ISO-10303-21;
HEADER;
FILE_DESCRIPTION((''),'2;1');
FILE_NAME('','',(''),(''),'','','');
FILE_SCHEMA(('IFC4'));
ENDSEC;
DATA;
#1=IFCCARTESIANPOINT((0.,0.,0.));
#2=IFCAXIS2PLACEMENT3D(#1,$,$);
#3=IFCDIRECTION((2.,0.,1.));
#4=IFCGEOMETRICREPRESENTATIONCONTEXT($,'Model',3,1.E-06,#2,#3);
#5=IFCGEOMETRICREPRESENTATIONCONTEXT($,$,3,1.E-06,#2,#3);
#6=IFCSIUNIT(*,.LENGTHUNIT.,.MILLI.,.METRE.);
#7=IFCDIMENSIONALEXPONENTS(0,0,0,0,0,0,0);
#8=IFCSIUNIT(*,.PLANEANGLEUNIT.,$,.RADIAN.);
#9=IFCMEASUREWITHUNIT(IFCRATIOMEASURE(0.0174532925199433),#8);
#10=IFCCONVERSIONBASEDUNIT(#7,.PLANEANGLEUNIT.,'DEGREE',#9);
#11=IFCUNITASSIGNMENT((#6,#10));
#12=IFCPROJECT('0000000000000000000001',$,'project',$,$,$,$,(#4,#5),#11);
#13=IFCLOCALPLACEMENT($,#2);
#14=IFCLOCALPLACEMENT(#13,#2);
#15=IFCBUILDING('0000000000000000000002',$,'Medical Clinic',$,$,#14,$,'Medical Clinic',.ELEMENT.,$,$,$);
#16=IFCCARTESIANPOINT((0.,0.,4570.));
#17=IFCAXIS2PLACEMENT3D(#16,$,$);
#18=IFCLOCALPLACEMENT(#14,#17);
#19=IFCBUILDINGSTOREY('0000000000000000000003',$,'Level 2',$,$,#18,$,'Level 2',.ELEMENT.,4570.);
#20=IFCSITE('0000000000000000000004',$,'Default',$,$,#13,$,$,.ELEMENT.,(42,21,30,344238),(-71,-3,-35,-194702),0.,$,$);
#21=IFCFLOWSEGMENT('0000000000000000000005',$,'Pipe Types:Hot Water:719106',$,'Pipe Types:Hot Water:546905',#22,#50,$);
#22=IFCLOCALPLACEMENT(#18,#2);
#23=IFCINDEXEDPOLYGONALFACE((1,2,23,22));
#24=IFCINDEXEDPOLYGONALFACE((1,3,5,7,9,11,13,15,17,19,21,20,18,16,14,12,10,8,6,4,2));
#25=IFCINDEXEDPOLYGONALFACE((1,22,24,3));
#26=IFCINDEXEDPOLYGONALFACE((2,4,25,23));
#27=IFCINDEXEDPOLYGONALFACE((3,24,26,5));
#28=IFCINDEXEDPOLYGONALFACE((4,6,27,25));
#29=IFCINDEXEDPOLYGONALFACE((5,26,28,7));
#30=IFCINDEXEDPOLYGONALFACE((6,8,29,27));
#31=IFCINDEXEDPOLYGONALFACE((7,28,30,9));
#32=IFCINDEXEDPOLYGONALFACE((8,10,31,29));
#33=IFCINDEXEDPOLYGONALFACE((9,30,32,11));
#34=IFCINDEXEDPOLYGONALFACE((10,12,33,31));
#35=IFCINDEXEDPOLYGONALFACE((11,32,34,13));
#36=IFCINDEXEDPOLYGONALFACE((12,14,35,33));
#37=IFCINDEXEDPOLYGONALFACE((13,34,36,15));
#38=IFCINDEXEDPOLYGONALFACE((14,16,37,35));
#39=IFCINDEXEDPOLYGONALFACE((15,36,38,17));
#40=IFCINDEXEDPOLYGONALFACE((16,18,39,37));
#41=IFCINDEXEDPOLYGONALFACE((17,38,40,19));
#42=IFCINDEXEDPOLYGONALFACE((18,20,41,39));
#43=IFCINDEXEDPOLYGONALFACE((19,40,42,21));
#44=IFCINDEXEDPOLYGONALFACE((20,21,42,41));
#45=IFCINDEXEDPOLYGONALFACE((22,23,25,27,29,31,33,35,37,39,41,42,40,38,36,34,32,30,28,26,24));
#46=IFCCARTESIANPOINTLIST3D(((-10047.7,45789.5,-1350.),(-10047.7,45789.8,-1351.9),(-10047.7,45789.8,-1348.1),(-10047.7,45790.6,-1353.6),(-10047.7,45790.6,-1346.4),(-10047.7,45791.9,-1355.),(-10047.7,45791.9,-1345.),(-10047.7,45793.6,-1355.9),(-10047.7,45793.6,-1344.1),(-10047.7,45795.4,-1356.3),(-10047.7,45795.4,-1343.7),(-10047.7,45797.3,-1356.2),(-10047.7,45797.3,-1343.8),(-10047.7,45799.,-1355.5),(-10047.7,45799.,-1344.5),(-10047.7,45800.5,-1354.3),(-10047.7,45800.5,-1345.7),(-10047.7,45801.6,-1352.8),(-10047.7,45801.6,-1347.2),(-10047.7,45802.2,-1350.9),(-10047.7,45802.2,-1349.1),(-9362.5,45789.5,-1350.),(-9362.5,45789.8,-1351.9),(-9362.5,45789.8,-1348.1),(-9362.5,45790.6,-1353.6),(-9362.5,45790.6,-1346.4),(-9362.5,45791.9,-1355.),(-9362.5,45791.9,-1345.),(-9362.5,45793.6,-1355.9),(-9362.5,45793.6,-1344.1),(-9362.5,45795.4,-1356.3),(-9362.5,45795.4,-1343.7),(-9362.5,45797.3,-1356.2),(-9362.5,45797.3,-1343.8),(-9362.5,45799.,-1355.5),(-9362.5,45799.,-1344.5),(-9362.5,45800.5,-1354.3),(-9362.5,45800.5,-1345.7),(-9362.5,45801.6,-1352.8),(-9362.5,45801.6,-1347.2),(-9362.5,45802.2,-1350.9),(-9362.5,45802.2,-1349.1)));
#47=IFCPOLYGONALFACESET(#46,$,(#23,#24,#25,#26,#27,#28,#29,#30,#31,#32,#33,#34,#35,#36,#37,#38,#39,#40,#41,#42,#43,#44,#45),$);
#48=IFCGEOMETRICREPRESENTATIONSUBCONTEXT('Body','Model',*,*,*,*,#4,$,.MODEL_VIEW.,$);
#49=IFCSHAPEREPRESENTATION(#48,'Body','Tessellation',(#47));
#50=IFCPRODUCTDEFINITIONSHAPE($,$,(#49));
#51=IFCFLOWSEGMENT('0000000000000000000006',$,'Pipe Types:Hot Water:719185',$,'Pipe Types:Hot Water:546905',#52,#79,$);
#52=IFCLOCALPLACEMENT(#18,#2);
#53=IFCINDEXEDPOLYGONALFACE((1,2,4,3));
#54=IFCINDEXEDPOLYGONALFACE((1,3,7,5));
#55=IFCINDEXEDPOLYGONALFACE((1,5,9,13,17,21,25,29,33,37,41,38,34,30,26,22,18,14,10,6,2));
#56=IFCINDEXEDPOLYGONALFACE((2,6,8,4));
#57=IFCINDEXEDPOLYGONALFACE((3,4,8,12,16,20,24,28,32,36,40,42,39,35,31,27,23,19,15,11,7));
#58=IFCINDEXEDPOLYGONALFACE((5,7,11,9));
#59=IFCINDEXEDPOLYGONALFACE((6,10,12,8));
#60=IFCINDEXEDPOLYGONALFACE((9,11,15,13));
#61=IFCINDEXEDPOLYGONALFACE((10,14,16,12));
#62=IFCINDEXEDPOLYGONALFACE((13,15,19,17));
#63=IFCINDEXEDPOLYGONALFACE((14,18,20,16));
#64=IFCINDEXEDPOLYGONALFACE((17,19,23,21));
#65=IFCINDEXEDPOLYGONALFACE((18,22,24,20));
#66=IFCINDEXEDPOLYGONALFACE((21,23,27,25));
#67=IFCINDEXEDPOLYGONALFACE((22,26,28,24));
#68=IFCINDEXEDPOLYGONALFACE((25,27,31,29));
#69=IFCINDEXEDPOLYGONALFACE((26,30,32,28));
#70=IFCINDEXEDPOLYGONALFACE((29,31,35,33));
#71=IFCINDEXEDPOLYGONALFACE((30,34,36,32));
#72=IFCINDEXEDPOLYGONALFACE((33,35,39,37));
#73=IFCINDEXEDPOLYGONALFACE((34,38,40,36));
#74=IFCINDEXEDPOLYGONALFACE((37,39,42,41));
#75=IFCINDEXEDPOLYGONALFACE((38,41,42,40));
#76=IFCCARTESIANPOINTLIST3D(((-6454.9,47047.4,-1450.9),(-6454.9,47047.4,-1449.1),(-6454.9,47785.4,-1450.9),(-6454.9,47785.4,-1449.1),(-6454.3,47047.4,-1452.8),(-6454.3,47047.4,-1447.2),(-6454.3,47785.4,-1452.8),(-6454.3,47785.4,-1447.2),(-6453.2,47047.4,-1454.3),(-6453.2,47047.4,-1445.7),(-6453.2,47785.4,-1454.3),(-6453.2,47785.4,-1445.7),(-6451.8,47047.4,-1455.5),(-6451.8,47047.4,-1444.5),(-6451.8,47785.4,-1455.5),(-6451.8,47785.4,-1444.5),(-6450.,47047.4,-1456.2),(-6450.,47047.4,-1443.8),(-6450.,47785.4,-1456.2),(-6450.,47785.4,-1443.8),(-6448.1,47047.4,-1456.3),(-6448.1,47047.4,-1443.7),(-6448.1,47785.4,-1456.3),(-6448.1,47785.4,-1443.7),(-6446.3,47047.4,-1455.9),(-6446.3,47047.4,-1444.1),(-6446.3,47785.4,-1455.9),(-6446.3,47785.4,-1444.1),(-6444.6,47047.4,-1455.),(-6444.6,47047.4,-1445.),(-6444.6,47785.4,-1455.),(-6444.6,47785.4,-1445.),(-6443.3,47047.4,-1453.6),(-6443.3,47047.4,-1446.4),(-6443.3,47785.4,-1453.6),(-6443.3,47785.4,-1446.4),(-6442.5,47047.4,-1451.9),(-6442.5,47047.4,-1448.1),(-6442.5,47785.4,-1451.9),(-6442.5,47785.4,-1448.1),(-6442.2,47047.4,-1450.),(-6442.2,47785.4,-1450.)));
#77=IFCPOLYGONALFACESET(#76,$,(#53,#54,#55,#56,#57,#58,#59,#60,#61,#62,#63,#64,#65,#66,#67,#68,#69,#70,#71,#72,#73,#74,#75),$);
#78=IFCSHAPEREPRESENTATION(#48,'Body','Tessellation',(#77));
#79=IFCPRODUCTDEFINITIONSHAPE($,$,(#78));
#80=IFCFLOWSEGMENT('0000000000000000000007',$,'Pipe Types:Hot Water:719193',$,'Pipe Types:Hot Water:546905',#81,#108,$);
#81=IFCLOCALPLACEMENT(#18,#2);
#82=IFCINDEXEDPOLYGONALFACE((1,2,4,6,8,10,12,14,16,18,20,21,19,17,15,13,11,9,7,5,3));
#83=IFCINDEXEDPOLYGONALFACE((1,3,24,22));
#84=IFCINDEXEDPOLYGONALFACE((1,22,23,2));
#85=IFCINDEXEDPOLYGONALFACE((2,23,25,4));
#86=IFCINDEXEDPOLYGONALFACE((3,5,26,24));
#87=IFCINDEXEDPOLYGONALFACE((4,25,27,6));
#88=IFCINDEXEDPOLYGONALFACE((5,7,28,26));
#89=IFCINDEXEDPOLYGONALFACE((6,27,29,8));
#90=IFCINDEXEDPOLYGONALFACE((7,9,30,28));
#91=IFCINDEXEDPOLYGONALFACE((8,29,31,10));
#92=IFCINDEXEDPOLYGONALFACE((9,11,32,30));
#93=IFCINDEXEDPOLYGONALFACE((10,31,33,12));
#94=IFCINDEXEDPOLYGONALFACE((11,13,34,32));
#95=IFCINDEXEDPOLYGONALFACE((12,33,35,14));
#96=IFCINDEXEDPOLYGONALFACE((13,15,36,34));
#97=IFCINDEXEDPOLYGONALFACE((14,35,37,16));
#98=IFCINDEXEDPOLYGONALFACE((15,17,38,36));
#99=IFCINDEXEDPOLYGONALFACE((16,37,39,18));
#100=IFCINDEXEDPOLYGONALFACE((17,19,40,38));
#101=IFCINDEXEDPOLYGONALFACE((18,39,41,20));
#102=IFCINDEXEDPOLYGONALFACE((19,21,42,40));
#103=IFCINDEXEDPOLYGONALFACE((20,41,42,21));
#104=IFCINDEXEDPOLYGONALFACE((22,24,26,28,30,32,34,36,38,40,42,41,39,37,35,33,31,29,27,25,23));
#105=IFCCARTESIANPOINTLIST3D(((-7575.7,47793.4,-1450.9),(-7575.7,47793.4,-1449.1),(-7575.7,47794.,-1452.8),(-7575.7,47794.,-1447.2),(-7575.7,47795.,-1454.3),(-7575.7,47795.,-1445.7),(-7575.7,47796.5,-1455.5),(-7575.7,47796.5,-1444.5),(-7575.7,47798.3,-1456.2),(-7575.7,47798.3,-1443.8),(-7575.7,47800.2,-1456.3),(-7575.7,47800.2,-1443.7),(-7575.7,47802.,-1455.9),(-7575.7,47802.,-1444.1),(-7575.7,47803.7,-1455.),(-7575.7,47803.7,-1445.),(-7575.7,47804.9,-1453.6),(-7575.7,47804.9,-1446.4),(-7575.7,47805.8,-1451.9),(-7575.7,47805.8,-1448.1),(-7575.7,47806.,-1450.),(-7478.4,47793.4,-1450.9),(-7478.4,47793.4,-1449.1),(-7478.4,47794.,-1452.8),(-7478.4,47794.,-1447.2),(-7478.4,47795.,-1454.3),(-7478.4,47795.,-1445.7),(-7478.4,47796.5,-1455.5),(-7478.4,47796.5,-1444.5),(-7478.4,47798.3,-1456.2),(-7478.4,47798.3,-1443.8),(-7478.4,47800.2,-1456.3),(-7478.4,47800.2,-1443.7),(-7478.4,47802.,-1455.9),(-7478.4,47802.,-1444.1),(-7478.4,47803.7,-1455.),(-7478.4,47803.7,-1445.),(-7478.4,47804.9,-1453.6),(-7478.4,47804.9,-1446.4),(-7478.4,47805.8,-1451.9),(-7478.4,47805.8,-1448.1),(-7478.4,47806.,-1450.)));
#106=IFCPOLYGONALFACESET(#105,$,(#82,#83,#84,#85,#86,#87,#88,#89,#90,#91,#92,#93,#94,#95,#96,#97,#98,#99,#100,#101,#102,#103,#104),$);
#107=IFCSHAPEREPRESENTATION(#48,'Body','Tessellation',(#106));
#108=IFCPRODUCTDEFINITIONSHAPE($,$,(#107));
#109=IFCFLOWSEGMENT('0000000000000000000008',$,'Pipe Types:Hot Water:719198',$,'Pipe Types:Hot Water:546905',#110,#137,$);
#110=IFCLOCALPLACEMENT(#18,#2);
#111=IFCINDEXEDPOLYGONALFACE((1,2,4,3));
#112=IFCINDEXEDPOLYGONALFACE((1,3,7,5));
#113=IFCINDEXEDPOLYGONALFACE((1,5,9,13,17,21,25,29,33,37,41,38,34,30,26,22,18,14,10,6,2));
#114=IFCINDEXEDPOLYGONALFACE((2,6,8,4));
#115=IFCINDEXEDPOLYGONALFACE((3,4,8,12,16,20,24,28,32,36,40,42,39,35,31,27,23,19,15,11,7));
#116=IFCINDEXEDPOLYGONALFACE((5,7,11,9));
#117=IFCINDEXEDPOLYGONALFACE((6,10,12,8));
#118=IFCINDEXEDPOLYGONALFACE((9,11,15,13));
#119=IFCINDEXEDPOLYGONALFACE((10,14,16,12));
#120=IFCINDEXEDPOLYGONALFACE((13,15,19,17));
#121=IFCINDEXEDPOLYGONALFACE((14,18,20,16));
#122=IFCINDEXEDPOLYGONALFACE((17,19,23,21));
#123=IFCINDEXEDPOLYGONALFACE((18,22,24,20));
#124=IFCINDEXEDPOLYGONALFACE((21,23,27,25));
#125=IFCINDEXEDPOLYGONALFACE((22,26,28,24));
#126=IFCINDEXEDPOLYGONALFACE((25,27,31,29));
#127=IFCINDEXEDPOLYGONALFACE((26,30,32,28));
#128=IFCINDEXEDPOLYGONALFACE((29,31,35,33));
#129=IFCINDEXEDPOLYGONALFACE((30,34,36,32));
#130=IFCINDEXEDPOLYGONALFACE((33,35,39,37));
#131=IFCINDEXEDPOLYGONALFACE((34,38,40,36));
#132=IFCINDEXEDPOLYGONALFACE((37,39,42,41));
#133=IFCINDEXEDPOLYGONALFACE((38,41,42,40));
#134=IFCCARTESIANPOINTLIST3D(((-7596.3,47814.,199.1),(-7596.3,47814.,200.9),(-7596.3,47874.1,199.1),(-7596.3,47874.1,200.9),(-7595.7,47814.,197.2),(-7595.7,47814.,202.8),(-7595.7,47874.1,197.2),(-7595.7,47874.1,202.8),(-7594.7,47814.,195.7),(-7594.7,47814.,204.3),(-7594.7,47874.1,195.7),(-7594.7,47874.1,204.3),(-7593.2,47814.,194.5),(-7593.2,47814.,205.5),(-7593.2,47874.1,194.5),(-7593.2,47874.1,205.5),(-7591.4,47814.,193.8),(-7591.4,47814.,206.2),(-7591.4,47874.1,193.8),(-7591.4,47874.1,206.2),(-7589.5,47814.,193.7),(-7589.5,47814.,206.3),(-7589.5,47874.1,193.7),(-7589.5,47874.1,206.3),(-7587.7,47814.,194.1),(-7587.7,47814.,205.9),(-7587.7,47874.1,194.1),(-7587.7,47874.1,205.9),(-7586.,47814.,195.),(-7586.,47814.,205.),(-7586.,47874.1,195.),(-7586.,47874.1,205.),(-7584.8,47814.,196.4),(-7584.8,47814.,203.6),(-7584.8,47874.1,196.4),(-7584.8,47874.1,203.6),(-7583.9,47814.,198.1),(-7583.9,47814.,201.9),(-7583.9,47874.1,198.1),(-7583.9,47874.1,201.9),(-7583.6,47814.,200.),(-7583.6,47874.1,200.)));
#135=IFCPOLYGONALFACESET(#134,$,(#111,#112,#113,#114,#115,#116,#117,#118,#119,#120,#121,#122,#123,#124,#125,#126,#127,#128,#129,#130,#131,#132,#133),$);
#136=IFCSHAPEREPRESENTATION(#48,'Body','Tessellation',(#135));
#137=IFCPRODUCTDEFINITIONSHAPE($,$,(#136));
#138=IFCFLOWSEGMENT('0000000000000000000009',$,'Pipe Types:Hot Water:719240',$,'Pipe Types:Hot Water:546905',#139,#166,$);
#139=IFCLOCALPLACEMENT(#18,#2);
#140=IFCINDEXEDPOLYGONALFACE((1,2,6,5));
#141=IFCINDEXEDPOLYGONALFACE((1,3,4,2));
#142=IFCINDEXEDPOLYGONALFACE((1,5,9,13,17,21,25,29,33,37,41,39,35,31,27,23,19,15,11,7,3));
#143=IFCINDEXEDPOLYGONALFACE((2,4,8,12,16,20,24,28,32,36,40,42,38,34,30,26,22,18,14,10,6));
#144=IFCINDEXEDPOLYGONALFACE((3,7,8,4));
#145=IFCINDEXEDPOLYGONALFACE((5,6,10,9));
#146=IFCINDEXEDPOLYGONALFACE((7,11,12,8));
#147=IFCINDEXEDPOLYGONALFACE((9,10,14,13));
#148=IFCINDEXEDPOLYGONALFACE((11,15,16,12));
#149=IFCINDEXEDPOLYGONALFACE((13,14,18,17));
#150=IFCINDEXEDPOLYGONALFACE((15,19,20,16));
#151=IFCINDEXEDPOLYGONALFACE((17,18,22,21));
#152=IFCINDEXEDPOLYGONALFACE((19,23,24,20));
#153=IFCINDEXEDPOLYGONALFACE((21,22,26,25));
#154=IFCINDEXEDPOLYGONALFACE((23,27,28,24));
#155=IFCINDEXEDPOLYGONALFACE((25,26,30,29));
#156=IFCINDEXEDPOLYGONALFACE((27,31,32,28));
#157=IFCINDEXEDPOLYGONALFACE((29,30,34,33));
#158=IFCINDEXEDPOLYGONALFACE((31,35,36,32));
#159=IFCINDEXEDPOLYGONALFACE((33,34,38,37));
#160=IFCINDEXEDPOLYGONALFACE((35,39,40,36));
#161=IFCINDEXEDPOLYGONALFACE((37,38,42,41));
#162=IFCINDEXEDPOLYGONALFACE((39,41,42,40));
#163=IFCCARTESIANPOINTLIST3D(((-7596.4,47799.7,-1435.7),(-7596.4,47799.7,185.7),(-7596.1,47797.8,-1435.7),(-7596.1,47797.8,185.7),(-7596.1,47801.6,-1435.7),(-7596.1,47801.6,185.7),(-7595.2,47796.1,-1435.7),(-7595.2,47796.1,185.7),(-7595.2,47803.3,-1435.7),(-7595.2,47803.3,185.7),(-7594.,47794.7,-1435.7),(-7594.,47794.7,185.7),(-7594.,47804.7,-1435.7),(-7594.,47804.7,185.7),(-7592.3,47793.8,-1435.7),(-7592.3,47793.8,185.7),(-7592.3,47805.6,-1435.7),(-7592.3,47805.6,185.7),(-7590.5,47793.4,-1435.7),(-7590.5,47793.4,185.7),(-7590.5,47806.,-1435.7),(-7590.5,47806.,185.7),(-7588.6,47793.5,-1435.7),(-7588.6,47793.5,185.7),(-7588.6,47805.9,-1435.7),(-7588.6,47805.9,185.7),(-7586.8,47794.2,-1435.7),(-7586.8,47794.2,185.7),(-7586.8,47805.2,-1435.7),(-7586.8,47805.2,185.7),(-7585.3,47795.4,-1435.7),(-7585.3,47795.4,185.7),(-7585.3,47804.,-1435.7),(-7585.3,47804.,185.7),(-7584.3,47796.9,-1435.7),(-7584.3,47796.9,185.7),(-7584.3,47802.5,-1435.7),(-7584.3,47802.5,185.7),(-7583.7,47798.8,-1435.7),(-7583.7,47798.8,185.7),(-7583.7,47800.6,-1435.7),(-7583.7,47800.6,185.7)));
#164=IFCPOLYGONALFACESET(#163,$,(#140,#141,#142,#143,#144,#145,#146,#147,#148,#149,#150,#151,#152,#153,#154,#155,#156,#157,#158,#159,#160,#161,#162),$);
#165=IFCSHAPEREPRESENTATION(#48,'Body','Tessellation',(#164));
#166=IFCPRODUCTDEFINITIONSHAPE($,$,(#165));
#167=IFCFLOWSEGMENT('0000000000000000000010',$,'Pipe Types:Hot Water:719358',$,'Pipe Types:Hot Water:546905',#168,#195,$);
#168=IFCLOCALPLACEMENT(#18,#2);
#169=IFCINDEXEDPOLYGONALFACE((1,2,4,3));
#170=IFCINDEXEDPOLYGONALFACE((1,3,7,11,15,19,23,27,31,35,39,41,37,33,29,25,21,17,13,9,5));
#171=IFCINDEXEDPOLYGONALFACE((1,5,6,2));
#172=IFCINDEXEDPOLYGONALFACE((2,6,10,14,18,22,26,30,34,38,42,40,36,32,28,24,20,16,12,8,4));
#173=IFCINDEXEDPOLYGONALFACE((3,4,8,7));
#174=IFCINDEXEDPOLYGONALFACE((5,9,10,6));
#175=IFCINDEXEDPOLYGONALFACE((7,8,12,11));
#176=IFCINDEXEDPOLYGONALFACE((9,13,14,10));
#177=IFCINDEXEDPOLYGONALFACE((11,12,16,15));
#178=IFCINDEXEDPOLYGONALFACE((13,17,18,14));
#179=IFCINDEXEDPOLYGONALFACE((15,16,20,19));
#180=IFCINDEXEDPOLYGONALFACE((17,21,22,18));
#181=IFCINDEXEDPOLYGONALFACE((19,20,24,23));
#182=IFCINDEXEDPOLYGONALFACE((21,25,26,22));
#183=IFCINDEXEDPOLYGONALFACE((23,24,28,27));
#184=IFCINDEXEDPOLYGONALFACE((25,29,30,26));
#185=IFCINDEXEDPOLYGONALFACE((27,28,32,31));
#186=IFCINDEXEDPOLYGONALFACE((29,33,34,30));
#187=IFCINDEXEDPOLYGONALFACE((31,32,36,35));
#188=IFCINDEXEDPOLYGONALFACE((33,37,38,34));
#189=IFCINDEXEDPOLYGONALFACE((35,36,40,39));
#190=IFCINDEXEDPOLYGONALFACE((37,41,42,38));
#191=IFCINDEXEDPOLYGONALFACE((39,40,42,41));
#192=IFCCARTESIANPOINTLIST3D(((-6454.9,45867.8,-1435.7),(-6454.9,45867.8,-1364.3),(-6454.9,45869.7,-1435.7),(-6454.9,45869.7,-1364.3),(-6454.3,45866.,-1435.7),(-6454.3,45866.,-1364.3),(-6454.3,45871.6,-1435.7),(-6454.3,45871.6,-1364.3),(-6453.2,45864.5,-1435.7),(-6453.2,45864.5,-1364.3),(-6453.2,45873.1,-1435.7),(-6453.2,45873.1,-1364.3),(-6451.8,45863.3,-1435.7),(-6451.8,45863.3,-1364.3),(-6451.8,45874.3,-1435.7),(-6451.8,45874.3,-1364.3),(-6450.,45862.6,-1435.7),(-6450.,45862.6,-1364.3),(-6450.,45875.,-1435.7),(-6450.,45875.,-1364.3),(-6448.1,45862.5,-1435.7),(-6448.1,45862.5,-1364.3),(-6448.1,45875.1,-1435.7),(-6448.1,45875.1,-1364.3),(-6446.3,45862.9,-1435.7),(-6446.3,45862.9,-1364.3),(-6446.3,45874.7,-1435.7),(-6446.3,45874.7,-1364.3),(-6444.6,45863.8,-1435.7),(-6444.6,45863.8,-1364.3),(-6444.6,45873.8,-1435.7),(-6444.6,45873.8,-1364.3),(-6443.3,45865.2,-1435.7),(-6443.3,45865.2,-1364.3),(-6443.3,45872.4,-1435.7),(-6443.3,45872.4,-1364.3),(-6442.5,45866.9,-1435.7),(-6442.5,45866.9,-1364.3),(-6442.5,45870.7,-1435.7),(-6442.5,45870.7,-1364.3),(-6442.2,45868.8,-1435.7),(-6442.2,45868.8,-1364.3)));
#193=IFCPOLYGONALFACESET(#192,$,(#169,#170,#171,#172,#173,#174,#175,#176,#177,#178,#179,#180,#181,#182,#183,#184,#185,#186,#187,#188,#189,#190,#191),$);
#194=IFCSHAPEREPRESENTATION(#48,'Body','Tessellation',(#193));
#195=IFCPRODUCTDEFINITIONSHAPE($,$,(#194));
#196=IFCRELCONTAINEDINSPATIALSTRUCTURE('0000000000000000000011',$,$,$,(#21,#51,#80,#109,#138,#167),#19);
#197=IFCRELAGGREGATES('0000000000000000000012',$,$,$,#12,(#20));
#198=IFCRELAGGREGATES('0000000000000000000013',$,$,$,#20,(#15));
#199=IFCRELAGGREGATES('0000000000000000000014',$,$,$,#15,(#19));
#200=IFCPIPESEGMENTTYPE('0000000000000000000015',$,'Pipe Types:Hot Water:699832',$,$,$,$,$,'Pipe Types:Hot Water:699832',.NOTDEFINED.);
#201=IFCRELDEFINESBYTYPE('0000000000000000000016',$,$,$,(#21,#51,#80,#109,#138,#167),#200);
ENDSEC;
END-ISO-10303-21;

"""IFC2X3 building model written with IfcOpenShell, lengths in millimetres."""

from ifc_helpers import new_model, entity, si_unit, converted_unit, direction, frame, frame_2d, origin, origin_2d_with_axis, place, context, subcontext, project, spatial, circle, extrude, type_object, element, save


model = new_model("IFC2X3")

# Units and contexts
model_context = context("Model", 3, precision=1e-06, world=origin(), true_north=direction((2.0, 0.0, 1.0)))
context_of_model = context(None, 3, precision=1e-06, world=origin(), true_north=direction((2.0, 0.0, 1.0)))
body_context = subcontext(model_context, "Body", "Model", "MODEL_VIEW")
ifc_project = project(units=[si_unit("LENGTHUNIT", "METRE", prefix="MILLI"), converted_unit("PLANEANGLEUNIT", "DEGREE", entity("IfcRatioMeasure", 0.0174532925199433), si_unit("PLANEANGLEUNIT", "RADIAN"), dimensions=[0, 0, 0, 0, 0, 0, 0])], contexts=[model_context, context_of_model])

# Site, building, storey
site_placement = place(None, origin())
site = spatial("IfcSite", under=ifc_project, at=site_placement, Name="Default", CompositionType="ELEMENT", RefLatitude=(42, 21, 30, 344238), RefLongitude=(-71, -3, -35, -194702), RefElevation=0.0)
building_placement = place(site_placement, origin())
building = spatial("IfcBuilding", under=site, at=building_placement, Name="Medical Clinic", LongName="Medical Clinic", CompositionType="ELEMENT")
storey_placement = place(building_placement, frame((0.0, 0.0, 4570.0)))
storey = spatial("IfcBuildingStorey", under=building, at=storey_placement, Name="Level 2", LongName="Level 2", CompositionType="ELEMENT", Elevation=4570.0)

# Flow segments
pipe_segment_type_1 = type_object("IfcPipeSegmentType", Name="Pipe Types:Hot Water:699832", ElementType="Pipe Types:Hot Water:699832", PredefinedType="NOTDEFINED")
flow_segment_1_placement = place(storey_placement, origin())
element("IfcFlowSegment", 1, at=flow_segment_1_placement, inside=storey, type_object=pipe_segment_type_1, Name="Pipe Types:Hot Water:719106", ObjectType="Pipe Types:Hot Water:546905", context=body_context, shape_type="SweptSolid", body=[
    extrude(circle(Radius=6.3, at=origin_2d_with_axis()), frame((-10047.7, 45795.9, -1350.0), z_axis=(1.0, 0.0, 0.0), x_axis=(0.0, -1.0, 0.0)), (0.0, 0.0, 1.0), 685.2),
])
flow_segment_2_placement = place(storey_placement, origin())
element("IfcFlowSegment", 2, at=flow_segment_2_placement, inside=storey, type_object=pipe_segment_type_1, Name="Pipe Types:Hot Water:719185", ObjectType="Pipe Types:Hot Water:546905", context=body_context, shape_type="SweptSolid", body=[
    extrude(circle(Radius=6.3, at=origin_2d_with_axis()), frame((-6448.6, 47047.4, -1450.0), z_axis=(0.0, 1.0, 0.0), x_axis=(1.0, 0.0, 0.0)), (0.0, 0.0, 1.0), 738.0),
])
flow_segment_3_placement = place(storey_placement, origin())
element("IfcFlowSegment", 3, at=flow_segment_3_placement, inside=storey, type_object=pipe_segment_type_1, Name="Pipe Types:Hot Water:719193", ObjectType="Pipe Types:Hot Water:546905", context=body_context, shape_type="SweptSolid", body=[
    extrude(circle(Radius=6.3, at=origin_2d_with_axis()), frame((-7575.7, 47799.7, -1450.0), z_axis=(1.0, 0.0, 0.0), x_axis=(0.0, 1.0, 0.0)), (0.0, 0.0, 1.0), 97.3),
])
flow_segment_4_placement = place(storey_placement, origin())
element("IfcFlowSegment", 4, at=flow_segment_4_placement, inside=storey, type_object=pipe_segment_type_1, Name="Pipe Types:Hot Water:719198", ObjectType="Pipe Types:Hot Water:546905", context=body_context, shape_type="SweptSolid", body=[
    extrude(circle(Radius=6.3, at=origin_2d_with_axis()), frame((-7590.0, 47814.0, 200.0), z_axis=(0.0, 1.0, 0.0), x_axis=(1.0, 0.0, 0.0)), (0.0, 0.0, 1.0), 60.1),
])
flow_segment_5_placement = place(storey_placement, origin())
element("IfcFlowSegment", 5, at=flow_segment_5_placement, inside=storey, type_object=pipe_segment_type_1, Name="Pipe Types:Hot Water:719240", ObjectType="Pipe Types:Hot Water:546905", context=body_context, shape_type="SweptSolid", body=[
    extrude(circle(Radius=6.3, at=frame_2d((0.0, 0.0), x_axis=(1.0, 0.0))), frame((-7590.0, 47799.7, -1435.7), z_axis=(0.0, 0.0, 1.0), x_axis=(-1.0, 0.0, 0.0)), (0.0, 0.0, 1.0), 1621.4),
])
flow_segment_6_placement = place(storey_placement, origin())
element("IfcFlowSegment", 6, at=flow_segment_6_placement, inside=storey, type_object=pipe_segment_type_1, Name="Pipe Types:Hot Water:719358", ObjectType="Pipe Types:Hot Water:546905", context=body_context, shape_type="SweptSolid", body=[
    extrude(circle(Radius=6.3, at=origin_2d_with_axis()), frame((-6448.6, 45868.8, -1435.7)), (0.0, 0.0, 1.0), 71.4),
])

save(model, "model.ifc")
